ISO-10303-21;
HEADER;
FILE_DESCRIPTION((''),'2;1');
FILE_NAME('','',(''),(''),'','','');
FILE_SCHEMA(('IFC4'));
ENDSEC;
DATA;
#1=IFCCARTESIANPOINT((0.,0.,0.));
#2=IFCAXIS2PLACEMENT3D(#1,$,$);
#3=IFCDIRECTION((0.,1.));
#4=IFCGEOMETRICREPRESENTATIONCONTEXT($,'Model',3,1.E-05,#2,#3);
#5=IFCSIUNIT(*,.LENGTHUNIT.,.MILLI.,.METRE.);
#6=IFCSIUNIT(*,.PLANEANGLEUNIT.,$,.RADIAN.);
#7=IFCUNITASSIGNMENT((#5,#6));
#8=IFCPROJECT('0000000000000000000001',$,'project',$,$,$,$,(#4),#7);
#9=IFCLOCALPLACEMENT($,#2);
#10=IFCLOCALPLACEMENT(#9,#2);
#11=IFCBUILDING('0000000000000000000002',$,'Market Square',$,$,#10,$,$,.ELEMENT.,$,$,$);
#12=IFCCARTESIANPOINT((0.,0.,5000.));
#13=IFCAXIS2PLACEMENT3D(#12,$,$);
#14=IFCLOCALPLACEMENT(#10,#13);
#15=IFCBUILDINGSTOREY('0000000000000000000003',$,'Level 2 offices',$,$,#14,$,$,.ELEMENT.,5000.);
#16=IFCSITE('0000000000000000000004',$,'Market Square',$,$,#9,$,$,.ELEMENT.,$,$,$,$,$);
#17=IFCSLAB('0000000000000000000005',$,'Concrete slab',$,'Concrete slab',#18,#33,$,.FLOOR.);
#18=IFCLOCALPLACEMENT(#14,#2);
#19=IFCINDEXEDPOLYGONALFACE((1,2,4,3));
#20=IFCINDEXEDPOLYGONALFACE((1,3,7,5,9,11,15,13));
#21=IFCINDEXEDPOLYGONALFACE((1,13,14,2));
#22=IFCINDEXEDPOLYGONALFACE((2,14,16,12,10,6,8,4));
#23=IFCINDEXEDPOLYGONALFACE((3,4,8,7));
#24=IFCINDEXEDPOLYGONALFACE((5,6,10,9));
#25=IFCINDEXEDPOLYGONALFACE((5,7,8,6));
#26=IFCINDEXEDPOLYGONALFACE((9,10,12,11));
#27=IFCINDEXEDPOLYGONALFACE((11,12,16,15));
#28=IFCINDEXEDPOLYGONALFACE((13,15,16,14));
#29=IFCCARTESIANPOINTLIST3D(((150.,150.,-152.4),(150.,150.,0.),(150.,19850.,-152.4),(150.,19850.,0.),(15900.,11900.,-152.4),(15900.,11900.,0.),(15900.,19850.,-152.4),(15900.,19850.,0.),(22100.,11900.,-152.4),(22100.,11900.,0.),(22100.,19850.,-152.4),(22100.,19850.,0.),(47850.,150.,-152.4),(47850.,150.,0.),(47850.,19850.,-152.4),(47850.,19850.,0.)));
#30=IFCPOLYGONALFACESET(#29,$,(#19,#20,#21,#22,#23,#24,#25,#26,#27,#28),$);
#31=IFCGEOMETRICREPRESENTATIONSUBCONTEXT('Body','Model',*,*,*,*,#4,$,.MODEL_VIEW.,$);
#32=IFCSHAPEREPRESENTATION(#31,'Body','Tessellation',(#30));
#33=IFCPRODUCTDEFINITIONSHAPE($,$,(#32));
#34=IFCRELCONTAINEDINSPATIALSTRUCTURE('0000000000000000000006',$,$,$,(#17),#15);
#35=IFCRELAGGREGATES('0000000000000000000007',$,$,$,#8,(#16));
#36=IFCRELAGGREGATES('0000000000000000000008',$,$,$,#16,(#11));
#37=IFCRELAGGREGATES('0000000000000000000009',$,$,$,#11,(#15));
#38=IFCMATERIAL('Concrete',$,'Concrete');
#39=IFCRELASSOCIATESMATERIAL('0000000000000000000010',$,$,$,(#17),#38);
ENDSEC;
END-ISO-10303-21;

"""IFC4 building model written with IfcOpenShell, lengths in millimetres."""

from ifc_helpers import new_model, si_unit, direction, frame, origin, origin_with_axes, place, context, subcontext, project, spatial, polyline, outline, extrude, material, element, save


model = new_model("IFC4")

# Units and contexts
model_context = context("Model", 3, precision=1e-05, world=origin(), true_north=direction((0.0, 1.0)))
body_context = subcontext(model_context, "Body", "Model", "MODEL_VIEW")
ifc_project = project(units=[si_unit("LENGTHUNIT", "METRE", prefix="MILLI"), si_unit("PLANEANGLEUNIT", "RADIAN")], contexts=[model_context])

# Site, building, storey
site_placement = place(None, origin())
site = spatial("IfcSite", under=ifc_project, at=site_placement, Name="Market Square", CompositionType="ELEMENT")
building_placement = place(site_placement, origin())
building = spatial("IfcBuilding", under=site, at=building_placement, Name="Market Square", CompositionType="ELEMENT")
storey_placement = place(building_placement, frame((0.0, 0.0, 5000.0)))
storey = spatial("IfcBuildingStorey", under=building, at=storey_placement, Name="Level 2 offices", CompositionType="ELEMENT", Elevation=5000.0)

# Slab
ifc_material_1 = material(Name="Concrete", Category="Concrete")
slab_placement = place(storey_placement, origin_with_axes())
element("IfcSlab", 1, at=slab_placement, inside=storey, material=ifc_material_1, Name="Concrete slab", ObjectType="Concrete slab", PredefinedType="FLOOR", context=body_context, shape_type="SweptSolid", body=[
    extrude(outline(polyline([(150.0, 150.0), (47850.0, 150.0), (47850.0, 19850.0), (22100.0, 19850.0), (22100.0, 11900.0), (15900.0, 11900.0), (15900.0, 19850.0), (150.0, 19850.0), (150.0, 150.0)])), frame((0.0, 0.0, -152.4)), (0.0, 0.0, 1.0), 152.4),
])

save(model, "model.ifc")
